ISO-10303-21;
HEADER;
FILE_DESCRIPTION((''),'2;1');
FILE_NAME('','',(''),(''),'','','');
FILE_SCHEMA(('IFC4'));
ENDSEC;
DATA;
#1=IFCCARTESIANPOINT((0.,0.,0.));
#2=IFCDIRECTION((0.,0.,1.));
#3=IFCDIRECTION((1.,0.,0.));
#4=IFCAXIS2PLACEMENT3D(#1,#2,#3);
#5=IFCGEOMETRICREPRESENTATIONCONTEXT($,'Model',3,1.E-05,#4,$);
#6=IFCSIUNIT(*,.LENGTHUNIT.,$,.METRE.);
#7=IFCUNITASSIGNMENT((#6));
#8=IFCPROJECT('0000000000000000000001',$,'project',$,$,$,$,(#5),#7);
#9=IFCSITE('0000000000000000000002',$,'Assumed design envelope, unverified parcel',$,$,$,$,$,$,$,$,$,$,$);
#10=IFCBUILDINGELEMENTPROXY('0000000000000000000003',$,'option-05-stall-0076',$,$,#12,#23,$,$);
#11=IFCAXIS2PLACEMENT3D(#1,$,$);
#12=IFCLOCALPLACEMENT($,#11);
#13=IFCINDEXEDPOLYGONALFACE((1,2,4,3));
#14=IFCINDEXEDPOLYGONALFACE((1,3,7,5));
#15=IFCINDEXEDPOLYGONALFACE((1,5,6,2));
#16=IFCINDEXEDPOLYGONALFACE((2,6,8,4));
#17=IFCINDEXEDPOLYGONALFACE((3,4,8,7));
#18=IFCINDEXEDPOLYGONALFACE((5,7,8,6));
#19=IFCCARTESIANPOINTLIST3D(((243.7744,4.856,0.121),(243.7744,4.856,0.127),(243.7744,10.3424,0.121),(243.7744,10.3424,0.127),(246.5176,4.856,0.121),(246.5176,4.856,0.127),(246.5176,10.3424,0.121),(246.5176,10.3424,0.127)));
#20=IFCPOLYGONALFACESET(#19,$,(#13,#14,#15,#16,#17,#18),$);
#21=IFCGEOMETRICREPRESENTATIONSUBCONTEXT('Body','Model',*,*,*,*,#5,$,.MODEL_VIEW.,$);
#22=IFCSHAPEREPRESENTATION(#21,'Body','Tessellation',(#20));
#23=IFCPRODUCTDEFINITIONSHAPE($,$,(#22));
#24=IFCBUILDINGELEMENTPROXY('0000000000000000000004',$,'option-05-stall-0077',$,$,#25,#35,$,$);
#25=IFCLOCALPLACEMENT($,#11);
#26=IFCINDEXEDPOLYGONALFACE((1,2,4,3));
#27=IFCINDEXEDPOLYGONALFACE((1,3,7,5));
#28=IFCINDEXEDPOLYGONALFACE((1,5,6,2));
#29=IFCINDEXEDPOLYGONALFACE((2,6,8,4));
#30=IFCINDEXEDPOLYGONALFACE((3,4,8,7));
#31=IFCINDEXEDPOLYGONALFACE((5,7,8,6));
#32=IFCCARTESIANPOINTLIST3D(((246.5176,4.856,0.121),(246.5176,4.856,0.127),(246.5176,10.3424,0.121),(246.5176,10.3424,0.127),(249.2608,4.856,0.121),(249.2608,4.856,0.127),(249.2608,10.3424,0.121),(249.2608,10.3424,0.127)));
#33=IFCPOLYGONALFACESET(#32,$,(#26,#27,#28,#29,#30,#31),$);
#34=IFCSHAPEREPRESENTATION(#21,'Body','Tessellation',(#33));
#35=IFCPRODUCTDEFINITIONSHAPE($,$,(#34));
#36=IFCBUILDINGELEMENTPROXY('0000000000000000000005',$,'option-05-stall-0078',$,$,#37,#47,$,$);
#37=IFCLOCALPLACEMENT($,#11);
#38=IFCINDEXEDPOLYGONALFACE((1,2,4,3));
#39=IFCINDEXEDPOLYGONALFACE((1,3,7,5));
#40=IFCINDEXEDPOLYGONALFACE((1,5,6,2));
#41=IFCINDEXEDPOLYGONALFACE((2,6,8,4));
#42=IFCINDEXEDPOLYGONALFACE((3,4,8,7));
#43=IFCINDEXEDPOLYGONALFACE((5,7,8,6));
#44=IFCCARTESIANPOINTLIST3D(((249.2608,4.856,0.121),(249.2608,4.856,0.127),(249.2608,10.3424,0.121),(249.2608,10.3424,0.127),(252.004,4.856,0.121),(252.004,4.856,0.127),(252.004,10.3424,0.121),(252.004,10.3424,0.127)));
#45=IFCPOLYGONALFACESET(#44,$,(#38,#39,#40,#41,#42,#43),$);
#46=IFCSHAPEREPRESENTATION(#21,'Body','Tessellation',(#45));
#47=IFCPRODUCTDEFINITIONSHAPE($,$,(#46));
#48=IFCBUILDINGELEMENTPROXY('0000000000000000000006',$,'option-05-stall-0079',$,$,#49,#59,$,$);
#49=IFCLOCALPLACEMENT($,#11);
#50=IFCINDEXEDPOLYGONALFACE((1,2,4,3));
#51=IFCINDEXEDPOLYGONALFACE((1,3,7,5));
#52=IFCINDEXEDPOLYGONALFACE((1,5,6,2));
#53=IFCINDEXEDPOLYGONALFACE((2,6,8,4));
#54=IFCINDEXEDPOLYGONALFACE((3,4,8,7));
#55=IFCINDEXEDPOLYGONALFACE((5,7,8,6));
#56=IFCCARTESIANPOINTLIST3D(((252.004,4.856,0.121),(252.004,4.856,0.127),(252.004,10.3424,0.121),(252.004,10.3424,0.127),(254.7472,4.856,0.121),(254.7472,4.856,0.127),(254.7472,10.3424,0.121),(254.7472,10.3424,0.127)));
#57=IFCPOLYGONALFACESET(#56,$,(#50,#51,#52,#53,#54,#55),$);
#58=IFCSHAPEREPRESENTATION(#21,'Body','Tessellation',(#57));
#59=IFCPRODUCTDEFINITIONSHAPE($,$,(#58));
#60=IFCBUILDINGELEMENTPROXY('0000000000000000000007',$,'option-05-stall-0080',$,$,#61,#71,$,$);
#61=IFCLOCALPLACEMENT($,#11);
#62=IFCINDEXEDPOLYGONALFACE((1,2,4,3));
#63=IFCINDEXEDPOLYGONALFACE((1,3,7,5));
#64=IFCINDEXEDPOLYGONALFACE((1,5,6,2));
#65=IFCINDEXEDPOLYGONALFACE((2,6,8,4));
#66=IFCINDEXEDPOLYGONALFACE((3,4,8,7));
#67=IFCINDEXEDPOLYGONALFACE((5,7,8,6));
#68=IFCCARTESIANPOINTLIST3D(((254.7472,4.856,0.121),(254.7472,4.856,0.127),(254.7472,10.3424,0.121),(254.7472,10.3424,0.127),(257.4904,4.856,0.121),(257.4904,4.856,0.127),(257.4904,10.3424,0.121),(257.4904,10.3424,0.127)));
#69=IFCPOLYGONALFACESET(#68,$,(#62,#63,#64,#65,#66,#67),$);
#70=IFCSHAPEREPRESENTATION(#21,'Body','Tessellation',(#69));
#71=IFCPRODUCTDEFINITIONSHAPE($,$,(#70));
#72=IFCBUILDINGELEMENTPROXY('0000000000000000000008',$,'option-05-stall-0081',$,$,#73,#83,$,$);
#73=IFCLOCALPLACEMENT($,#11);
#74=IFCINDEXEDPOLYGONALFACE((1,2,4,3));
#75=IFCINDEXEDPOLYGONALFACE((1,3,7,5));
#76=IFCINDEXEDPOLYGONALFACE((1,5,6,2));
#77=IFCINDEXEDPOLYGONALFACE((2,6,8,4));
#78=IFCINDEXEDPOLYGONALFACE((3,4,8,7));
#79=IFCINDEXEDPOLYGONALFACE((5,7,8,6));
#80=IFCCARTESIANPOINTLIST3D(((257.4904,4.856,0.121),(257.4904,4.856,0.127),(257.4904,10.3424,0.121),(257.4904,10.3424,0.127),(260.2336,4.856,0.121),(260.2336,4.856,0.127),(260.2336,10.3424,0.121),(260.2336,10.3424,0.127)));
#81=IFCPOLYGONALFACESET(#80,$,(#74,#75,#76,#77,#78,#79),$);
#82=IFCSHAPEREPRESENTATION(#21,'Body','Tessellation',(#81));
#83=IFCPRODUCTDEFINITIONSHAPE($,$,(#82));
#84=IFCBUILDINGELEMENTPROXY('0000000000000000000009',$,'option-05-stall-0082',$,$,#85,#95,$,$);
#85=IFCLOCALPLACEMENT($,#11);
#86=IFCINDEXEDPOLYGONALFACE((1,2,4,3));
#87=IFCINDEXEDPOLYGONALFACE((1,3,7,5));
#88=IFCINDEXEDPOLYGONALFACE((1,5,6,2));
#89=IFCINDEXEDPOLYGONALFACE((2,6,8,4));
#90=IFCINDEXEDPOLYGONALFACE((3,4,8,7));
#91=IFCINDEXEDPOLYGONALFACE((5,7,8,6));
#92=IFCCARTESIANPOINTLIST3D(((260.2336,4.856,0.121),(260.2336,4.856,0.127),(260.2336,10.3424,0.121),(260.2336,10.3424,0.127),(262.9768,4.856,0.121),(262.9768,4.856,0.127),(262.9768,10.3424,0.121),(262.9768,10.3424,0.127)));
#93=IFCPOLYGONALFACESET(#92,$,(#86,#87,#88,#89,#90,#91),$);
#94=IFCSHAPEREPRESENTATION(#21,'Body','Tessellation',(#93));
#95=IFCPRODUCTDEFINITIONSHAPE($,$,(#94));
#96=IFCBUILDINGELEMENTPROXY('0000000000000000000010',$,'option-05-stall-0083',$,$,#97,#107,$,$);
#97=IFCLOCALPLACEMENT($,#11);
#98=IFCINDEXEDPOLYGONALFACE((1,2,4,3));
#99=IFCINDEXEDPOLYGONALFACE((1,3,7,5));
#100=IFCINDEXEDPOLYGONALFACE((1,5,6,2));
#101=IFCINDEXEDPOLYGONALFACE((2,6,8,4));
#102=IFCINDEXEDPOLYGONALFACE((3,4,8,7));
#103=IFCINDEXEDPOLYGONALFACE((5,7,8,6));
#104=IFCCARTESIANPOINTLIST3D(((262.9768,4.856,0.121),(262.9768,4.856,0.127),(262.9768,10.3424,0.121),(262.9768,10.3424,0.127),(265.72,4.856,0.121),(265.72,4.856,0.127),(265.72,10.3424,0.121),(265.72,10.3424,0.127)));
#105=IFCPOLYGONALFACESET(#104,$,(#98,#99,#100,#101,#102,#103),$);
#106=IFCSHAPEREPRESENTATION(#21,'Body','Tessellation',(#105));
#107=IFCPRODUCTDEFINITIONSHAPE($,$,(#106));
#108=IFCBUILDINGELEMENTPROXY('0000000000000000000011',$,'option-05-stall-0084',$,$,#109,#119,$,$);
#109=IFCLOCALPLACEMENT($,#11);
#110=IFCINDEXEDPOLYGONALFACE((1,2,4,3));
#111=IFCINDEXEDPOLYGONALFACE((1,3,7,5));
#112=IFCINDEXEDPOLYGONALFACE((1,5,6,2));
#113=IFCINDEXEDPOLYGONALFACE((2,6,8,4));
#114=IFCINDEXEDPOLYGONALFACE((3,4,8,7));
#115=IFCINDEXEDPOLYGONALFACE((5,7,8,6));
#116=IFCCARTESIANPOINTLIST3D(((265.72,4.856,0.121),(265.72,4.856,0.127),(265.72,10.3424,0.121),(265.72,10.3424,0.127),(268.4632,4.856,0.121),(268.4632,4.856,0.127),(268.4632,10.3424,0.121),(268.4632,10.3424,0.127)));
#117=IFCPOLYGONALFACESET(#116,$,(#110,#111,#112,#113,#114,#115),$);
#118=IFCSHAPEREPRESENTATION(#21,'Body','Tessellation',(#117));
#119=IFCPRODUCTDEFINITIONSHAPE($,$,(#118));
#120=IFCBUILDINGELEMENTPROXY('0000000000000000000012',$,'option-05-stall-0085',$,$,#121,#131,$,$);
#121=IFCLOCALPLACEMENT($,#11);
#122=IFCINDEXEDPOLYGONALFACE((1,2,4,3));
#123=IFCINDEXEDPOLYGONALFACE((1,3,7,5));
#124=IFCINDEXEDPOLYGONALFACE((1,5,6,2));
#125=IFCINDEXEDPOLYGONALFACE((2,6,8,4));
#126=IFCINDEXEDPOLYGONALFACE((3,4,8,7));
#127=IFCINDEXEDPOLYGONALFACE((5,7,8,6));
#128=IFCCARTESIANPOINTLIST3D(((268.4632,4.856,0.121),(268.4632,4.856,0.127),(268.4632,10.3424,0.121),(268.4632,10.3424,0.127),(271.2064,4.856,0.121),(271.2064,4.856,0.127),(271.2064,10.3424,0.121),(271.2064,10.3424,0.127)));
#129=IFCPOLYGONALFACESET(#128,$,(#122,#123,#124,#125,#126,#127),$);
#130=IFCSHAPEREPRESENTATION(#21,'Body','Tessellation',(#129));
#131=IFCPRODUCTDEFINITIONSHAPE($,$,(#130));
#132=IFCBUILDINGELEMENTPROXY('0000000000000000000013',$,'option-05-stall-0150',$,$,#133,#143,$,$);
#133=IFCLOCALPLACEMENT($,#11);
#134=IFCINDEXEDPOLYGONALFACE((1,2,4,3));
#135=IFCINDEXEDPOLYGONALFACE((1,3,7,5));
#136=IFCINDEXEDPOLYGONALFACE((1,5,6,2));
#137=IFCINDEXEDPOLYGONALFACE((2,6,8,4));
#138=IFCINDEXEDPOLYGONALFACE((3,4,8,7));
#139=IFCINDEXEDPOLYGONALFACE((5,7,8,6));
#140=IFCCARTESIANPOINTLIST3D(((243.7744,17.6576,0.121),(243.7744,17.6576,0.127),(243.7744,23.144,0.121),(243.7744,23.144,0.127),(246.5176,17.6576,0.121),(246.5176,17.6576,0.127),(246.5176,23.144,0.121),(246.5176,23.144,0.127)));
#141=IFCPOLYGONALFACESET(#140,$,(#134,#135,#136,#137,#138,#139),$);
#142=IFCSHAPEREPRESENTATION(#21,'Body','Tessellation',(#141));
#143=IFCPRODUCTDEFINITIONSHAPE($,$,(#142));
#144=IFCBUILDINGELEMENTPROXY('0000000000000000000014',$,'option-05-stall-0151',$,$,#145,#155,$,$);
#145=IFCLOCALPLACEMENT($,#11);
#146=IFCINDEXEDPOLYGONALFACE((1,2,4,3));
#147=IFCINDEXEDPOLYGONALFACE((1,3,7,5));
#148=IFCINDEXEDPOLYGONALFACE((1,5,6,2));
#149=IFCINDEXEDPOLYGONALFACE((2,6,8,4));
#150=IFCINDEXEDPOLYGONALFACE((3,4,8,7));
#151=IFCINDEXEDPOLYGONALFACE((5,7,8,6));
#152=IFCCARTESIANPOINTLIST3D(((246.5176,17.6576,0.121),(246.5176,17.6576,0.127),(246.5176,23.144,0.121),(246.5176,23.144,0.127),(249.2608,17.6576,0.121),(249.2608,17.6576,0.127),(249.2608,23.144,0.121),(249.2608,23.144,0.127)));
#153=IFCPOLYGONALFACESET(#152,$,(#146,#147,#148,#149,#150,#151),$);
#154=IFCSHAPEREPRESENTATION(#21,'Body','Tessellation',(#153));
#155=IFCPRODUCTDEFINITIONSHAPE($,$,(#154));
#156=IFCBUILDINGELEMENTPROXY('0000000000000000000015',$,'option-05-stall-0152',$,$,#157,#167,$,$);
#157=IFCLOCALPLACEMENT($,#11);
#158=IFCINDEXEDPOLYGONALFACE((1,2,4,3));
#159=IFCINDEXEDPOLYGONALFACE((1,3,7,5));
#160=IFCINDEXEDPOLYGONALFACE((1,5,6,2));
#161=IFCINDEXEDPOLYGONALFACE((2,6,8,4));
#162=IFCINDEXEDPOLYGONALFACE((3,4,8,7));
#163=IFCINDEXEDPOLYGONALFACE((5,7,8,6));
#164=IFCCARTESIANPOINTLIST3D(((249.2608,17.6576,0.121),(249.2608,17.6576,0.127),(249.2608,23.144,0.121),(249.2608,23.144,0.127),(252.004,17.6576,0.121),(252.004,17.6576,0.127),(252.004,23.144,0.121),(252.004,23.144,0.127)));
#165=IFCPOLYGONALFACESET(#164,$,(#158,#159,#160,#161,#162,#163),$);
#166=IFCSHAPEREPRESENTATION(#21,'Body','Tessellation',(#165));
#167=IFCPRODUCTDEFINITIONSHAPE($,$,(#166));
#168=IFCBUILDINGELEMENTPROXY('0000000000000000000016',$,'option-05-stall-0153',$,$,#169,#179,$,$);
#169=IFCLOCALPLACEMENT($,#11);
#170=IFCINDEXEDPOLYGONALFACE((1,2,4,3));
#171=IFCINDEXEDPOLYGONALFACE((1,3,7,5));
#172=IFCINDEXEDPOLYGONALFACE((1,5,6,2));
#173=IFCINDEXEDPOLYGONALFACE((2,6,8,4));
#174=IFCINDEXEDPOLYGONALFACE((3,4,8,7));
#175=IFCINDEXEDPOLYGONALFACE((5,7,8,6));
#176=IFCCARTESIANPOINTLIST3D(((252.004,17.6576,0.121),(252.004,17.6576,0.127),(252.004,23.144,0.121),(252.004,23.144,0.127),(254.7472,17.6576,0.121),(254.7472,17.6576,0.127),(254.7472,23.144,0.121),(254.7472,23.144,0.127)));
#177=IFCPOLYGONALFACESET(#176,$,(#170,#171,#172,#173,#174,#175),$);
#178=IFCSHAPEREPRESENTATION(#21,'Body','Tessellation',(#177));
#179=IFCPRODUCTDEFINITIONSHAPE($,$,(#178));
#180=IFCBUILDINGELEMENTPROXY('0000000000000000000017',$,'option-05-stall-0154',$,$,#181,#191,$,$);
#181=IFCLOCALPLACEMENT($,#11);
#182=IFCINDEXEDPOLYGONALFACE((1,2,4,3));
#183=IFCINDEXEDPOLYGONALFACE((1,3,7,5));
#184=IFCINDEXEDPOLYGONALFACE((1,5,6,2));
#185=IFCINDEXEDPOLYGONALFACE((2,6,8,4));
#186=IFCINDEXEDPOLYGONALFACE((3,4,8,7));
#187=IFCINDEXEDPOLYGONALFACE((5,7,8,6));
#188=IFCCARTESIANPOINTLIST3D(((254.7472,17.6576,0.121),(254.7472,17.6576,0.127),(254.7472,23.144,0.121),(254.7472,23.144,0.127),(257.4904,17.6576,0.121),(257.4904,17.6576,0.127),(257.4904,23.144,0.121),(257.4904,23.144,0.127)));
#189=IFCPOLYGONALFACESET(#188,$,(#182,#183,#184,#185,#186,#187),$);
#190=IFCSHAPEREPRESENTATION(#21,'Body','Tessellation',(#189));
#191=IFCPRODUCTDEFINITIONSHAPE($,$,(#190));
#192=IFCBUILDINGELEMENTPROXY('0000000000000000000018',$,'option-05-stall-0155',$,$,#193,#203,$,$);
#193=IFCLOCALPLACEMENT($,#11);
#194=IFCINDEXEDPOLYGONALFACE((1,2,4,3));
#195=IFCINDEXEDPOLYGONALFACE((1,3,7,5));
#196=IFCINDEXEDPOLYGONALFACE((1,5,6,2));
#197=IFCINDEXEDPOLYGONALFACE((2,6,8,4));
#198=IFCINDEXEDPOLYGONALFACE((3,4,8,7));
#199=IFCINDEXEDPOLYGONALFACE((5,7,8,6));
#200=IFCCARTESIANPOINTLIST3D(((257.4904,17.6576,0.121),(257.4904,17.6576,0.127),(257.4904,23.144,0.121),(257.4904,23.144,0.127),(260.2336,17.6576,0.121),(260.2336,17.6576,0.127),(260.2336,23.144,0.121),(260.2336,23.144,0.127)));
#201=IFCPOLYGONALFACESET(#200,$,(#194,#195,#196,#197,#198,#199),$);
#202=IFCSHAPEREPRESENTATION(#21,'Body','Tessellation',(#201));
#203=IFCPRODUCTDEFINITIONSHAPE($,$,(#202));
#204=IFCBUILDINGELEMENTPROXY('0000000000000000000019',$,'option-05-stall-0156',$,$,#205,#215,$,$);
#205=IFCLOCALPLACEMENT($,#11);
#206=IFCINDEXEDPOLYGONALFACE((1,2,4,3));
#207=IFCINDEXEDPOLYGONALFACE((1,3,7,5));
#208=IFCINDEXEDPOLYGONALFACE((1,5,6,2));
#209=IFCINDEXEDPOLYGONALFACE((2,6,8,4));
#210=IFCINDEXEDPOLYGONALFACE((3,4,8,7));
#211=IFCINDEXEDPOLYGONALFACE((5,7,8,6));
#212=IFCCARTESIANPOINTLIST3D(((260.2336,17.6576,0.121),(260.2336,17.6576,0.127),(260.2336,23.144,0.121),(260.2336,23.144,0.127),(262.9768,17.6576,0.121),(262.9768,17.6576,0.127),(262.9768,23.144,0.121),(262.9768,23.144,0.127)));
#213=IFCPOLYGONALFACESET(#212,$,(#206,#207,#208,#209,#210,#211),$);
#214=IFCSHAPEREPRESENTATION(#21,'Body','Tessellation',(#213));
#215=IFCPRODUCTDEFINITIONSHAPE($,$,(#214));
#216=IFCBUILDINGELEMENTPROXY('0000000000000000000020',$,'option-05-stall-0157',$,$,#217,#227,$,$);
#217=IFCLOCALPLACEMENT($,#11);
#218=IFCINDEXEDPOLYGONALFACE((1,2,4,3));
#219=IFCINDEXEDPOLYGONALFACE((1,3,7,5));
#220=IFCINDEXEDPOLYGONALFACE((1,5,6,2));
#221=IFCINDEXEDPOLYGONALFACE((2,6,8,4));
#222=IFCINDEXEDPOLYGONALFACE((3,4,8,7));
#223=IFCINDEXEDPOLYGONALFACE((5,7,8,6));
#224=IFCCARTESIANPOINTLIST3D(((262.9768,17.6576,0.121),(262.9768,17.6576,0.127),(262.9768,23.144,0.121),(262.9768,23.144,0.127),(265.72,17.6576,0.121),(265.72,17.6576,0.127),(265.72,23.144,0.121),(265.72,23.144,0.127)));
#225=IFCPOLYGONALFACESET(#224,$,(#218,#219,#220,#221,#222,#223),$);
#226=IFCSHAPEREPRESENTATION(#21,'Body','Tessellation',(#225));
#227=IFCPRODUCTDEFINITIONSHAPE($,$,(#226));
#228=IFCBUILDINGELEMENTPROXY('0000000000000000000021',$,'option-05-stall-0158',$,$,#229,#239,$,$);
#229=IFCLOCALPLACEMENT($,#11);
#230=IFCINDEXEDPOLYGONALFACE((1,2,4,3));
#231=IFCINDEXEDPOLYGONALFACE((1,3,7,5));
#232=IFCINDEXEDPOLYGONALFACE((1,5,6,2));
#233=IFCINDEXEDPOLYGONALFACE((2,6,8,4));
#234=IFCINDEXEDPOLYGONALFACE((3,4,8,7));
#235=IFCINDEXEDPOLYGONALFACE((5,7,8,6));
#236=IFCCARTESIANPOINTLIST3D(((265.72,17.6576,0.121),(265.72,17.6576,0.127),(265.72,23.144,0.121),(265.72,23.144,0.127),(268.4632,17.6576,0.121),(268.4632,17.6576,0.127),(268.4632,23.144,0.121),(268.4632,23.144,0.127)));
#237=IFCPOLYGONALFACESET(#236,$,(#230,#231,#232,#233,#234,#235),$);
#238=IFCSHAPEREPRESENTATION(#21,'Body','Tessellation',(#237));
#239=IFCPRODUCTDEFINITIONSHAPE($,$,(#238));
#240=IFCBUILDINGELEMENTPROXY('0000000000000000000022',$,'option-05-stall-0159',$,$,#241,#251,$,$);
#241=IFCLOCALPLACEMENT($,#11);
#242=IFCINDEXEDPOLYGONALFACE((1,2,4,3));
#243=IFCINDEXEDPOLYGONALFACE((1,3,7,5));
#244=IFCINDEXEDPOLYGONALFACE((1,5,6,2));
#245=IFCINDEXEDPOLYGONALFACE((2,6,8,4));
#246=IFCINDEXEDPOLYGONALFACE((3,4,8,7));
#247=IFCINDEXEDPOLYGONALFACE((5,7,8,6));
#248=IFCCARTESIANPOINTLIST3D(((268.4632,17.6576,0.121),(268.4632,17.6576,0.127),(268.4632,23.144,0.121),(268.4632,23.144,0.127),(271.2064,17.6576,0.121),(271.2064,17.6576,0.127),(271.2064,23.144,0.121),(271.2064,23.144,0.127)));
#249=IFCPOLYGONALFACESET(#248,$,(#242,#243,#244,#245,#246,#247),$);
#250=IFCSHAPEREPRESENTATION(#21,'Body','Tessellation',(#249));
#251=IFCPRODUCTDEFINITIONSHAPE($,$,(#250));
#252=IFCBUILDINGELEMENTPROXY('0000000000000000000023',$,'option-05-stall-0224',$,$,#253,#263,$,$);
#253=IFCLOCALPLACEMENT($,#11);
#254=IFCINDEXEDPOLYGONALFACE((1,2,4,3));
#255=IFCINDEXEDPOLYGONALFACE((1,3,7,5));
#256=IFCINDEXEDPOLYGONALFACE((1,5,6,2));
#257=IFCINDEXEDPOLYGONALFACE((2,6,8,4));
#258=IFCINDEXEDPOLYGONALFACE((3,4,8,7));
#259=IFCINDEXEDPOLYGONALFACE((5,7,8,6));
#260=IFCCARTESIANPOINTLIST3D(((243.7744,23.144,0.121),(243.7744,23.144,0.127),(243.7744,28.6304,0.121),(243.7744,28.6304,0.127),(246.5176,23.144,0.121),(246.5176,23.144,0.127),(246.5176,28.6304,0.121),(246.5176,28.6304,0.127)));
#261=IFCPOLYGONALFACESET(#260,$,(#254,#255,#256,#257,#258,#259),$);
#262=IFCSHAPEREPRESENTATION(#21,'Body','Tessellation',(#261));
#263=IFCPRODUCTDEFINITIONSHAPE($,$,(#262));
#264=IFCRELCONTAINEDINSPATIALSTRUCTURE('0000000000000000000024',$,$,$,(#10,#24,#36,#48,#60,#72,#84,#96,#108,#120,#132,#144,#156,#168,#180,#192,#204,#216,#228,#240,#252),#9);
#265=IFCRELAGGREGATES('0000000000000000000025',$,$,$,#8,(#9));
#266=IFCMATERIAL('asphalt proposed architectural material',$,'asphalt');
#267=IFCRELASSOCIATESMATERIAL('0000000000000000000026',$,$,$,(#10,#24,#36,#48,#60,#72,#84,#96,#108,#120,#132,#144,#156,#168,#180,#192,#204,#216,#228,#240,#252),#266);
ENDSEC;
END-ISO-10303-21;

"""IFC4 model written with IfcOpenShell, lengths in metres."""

from ifc_helpers import new_model, si_unit, frame, origin_with_axes, place, context, subcontext, project, spatial, rectangle, extrude, material, element, save


model = new_model("IFC4")

# Units and contexts
model_context = context("Model", 3, precision=1e-05, world=origin_with_axes())
body_context = subcontext(model_context, "Body", "Model", "MODEL_VIEW")
ifc_project = project(units=[si_unit("LENGTHUNIT", "METRE")], contexts=[model_context])

# Site
site = spatial("IfcSite", under=ifc_project, Name="Assumed design envelope, unverified parcel")

# Building element proxies
ifc_material = material(Name="asphalt proposed architectural material", Category="asphalt")
for number, where, z_axis, x_axis, name in (
    (1, (245.146, 7.5992, 0.121), (0.0, 0.0, 1.0), (1.0, 0.0, 0.0), "option-05-stall-0076"),
    (2, (247.8892, 7.5992, 0.121), (0.0, 0.0, 1.0), (1.0, 0.0, 0.0), "option-05-stall-0077"),
    (3, (250.6324, 7.5992, 0.121), (0.0, 0.0, 1.0), (1.0, 0.0, 0.0), "option-05-stall-0078"),
    (4, (253.3756, 7.5992, 0.121), (0.0, 0.0, 1.0), (1.0, 0.0, 0.0), "option-05-stall-0079"),
    (5, (256.1188, 7.5992, 0.121), (0.0, 0.0, 1.0), (1.0, 0.0, 0.0), "option-05-stall-0080"),
    (6, (258.862, 7.5992, 0.121), (0.0, 0.0, 1.0), (1.0, 0.0, 0.0), "option-05-stall-0081"),
    (7, (261.6052, 7.5992, 0.121), (0.0, 0.0, 1.0), (1.0, 0.0, 0.0), "option-05-stall-0082"),
    (8, (264.3484, 7.5992, 0.121), (0.0, 0.0, 1.0), (1.0, 0.0, 0.0), "option-05-stall-0083"),
    (9, (267.0916, 7.5992, 0.121), (0.0, 0.0, 1.0), (1.0, 0.0, 0.0), "option-05-stall-0084"),
    (10, (269.8348, 7.5992, 0.121), (0.0, 0.0, 1.0), (1.0, 0.0, 0.0), "option-05-stall-0085"),
):
    element("IfcBuildingElementProxy", number, at=place(None, frame(where, z_axis=z_axis, x_axis=x_axis)), inside=site, material=ifc_material, Name=name, context=body_context, shape_type="SweptSolid", body=[
        extrude(rectangle(XDim=2.7432, YDim=5.4864), origin_with_axes(), (0.0, 0.0, 1.0), 0.006),
    ])
for number, where, z_axis, x_axis, name in (
    (11, (245.146, 20.4008, 0.121), (0.0, 0.0, 1.0), (1.0, 0.0, 0.0), "option-05-stall-0150"),
    (12, (247.8892, 20.4008, 0.121), (0.0, 0.0, 1.0), (1.0, 0.0, 0.0), "option-05-stall-0151"),
    (13, (250.6324, 20.4008, 0.121), (0.0, 0.0, 1.0), (1.0, 0.0, 0.0), "option-05-stall-0152"),
    (14, (253.3756, 20.4008, 0.121), (0.0, 0.0, 1.0), (1.0, 0.0, 0.0), "option-05-stall-0153"),
    (15, (256.1188, 20.4008, 0.121), (0.0, 0.0, 1.0), (1.0, 0.0, 0.0), "option-05-stall-0154"),
    (16, (258.862, 20.4008, 0.121), (0.0, 0.0, 1.0), (1.0, 0.0, 0.0), "option-05-stall-0155"),
    (17, (261.6052, 20.4008, 0.121), (0.0, 0.0, 1.0), (1.0, 0.0, 0.0), "option-05-stall-0156"),
    (18, (264.3484, 20.4008, 0.121), (0.0, 0.0, 1.0), (1.0, 0.0, 0.0), "option-05-stall-0157"),
    (19, (267.0916, 20.4008, 0.121), (0.0, 0.0, 1.0), (1.0, 0.0, 0.0), "option-05-stall-0158"),
    (20, (269.8348, 20.4008, 0.121), (0.0, 0.0, 1.0), (1.0, 0.0, 0.0), "option-05-stall-0159"),
    (21, (245.146, 25.8872, 0.121), (0.0, 0.0, 1.0), (1.0, 0.0, 0.0), "option-05-stall-0224"),
):
    element("IfcBuildingElementProxy", number, at=place(None, frame(where, z_axis=z_axis, x_axis=x_axis)), inside=site, material=ifc_material, Name=name, context=body_context, shape_type="SweptSolid", body=[
        extrude(rectangle(XDim=2.7432, YDim=5.4864), origin_with_axes(), (0.0, 0.0, 1.0), 0.006),
    ])

save(model, "model.ifc")
